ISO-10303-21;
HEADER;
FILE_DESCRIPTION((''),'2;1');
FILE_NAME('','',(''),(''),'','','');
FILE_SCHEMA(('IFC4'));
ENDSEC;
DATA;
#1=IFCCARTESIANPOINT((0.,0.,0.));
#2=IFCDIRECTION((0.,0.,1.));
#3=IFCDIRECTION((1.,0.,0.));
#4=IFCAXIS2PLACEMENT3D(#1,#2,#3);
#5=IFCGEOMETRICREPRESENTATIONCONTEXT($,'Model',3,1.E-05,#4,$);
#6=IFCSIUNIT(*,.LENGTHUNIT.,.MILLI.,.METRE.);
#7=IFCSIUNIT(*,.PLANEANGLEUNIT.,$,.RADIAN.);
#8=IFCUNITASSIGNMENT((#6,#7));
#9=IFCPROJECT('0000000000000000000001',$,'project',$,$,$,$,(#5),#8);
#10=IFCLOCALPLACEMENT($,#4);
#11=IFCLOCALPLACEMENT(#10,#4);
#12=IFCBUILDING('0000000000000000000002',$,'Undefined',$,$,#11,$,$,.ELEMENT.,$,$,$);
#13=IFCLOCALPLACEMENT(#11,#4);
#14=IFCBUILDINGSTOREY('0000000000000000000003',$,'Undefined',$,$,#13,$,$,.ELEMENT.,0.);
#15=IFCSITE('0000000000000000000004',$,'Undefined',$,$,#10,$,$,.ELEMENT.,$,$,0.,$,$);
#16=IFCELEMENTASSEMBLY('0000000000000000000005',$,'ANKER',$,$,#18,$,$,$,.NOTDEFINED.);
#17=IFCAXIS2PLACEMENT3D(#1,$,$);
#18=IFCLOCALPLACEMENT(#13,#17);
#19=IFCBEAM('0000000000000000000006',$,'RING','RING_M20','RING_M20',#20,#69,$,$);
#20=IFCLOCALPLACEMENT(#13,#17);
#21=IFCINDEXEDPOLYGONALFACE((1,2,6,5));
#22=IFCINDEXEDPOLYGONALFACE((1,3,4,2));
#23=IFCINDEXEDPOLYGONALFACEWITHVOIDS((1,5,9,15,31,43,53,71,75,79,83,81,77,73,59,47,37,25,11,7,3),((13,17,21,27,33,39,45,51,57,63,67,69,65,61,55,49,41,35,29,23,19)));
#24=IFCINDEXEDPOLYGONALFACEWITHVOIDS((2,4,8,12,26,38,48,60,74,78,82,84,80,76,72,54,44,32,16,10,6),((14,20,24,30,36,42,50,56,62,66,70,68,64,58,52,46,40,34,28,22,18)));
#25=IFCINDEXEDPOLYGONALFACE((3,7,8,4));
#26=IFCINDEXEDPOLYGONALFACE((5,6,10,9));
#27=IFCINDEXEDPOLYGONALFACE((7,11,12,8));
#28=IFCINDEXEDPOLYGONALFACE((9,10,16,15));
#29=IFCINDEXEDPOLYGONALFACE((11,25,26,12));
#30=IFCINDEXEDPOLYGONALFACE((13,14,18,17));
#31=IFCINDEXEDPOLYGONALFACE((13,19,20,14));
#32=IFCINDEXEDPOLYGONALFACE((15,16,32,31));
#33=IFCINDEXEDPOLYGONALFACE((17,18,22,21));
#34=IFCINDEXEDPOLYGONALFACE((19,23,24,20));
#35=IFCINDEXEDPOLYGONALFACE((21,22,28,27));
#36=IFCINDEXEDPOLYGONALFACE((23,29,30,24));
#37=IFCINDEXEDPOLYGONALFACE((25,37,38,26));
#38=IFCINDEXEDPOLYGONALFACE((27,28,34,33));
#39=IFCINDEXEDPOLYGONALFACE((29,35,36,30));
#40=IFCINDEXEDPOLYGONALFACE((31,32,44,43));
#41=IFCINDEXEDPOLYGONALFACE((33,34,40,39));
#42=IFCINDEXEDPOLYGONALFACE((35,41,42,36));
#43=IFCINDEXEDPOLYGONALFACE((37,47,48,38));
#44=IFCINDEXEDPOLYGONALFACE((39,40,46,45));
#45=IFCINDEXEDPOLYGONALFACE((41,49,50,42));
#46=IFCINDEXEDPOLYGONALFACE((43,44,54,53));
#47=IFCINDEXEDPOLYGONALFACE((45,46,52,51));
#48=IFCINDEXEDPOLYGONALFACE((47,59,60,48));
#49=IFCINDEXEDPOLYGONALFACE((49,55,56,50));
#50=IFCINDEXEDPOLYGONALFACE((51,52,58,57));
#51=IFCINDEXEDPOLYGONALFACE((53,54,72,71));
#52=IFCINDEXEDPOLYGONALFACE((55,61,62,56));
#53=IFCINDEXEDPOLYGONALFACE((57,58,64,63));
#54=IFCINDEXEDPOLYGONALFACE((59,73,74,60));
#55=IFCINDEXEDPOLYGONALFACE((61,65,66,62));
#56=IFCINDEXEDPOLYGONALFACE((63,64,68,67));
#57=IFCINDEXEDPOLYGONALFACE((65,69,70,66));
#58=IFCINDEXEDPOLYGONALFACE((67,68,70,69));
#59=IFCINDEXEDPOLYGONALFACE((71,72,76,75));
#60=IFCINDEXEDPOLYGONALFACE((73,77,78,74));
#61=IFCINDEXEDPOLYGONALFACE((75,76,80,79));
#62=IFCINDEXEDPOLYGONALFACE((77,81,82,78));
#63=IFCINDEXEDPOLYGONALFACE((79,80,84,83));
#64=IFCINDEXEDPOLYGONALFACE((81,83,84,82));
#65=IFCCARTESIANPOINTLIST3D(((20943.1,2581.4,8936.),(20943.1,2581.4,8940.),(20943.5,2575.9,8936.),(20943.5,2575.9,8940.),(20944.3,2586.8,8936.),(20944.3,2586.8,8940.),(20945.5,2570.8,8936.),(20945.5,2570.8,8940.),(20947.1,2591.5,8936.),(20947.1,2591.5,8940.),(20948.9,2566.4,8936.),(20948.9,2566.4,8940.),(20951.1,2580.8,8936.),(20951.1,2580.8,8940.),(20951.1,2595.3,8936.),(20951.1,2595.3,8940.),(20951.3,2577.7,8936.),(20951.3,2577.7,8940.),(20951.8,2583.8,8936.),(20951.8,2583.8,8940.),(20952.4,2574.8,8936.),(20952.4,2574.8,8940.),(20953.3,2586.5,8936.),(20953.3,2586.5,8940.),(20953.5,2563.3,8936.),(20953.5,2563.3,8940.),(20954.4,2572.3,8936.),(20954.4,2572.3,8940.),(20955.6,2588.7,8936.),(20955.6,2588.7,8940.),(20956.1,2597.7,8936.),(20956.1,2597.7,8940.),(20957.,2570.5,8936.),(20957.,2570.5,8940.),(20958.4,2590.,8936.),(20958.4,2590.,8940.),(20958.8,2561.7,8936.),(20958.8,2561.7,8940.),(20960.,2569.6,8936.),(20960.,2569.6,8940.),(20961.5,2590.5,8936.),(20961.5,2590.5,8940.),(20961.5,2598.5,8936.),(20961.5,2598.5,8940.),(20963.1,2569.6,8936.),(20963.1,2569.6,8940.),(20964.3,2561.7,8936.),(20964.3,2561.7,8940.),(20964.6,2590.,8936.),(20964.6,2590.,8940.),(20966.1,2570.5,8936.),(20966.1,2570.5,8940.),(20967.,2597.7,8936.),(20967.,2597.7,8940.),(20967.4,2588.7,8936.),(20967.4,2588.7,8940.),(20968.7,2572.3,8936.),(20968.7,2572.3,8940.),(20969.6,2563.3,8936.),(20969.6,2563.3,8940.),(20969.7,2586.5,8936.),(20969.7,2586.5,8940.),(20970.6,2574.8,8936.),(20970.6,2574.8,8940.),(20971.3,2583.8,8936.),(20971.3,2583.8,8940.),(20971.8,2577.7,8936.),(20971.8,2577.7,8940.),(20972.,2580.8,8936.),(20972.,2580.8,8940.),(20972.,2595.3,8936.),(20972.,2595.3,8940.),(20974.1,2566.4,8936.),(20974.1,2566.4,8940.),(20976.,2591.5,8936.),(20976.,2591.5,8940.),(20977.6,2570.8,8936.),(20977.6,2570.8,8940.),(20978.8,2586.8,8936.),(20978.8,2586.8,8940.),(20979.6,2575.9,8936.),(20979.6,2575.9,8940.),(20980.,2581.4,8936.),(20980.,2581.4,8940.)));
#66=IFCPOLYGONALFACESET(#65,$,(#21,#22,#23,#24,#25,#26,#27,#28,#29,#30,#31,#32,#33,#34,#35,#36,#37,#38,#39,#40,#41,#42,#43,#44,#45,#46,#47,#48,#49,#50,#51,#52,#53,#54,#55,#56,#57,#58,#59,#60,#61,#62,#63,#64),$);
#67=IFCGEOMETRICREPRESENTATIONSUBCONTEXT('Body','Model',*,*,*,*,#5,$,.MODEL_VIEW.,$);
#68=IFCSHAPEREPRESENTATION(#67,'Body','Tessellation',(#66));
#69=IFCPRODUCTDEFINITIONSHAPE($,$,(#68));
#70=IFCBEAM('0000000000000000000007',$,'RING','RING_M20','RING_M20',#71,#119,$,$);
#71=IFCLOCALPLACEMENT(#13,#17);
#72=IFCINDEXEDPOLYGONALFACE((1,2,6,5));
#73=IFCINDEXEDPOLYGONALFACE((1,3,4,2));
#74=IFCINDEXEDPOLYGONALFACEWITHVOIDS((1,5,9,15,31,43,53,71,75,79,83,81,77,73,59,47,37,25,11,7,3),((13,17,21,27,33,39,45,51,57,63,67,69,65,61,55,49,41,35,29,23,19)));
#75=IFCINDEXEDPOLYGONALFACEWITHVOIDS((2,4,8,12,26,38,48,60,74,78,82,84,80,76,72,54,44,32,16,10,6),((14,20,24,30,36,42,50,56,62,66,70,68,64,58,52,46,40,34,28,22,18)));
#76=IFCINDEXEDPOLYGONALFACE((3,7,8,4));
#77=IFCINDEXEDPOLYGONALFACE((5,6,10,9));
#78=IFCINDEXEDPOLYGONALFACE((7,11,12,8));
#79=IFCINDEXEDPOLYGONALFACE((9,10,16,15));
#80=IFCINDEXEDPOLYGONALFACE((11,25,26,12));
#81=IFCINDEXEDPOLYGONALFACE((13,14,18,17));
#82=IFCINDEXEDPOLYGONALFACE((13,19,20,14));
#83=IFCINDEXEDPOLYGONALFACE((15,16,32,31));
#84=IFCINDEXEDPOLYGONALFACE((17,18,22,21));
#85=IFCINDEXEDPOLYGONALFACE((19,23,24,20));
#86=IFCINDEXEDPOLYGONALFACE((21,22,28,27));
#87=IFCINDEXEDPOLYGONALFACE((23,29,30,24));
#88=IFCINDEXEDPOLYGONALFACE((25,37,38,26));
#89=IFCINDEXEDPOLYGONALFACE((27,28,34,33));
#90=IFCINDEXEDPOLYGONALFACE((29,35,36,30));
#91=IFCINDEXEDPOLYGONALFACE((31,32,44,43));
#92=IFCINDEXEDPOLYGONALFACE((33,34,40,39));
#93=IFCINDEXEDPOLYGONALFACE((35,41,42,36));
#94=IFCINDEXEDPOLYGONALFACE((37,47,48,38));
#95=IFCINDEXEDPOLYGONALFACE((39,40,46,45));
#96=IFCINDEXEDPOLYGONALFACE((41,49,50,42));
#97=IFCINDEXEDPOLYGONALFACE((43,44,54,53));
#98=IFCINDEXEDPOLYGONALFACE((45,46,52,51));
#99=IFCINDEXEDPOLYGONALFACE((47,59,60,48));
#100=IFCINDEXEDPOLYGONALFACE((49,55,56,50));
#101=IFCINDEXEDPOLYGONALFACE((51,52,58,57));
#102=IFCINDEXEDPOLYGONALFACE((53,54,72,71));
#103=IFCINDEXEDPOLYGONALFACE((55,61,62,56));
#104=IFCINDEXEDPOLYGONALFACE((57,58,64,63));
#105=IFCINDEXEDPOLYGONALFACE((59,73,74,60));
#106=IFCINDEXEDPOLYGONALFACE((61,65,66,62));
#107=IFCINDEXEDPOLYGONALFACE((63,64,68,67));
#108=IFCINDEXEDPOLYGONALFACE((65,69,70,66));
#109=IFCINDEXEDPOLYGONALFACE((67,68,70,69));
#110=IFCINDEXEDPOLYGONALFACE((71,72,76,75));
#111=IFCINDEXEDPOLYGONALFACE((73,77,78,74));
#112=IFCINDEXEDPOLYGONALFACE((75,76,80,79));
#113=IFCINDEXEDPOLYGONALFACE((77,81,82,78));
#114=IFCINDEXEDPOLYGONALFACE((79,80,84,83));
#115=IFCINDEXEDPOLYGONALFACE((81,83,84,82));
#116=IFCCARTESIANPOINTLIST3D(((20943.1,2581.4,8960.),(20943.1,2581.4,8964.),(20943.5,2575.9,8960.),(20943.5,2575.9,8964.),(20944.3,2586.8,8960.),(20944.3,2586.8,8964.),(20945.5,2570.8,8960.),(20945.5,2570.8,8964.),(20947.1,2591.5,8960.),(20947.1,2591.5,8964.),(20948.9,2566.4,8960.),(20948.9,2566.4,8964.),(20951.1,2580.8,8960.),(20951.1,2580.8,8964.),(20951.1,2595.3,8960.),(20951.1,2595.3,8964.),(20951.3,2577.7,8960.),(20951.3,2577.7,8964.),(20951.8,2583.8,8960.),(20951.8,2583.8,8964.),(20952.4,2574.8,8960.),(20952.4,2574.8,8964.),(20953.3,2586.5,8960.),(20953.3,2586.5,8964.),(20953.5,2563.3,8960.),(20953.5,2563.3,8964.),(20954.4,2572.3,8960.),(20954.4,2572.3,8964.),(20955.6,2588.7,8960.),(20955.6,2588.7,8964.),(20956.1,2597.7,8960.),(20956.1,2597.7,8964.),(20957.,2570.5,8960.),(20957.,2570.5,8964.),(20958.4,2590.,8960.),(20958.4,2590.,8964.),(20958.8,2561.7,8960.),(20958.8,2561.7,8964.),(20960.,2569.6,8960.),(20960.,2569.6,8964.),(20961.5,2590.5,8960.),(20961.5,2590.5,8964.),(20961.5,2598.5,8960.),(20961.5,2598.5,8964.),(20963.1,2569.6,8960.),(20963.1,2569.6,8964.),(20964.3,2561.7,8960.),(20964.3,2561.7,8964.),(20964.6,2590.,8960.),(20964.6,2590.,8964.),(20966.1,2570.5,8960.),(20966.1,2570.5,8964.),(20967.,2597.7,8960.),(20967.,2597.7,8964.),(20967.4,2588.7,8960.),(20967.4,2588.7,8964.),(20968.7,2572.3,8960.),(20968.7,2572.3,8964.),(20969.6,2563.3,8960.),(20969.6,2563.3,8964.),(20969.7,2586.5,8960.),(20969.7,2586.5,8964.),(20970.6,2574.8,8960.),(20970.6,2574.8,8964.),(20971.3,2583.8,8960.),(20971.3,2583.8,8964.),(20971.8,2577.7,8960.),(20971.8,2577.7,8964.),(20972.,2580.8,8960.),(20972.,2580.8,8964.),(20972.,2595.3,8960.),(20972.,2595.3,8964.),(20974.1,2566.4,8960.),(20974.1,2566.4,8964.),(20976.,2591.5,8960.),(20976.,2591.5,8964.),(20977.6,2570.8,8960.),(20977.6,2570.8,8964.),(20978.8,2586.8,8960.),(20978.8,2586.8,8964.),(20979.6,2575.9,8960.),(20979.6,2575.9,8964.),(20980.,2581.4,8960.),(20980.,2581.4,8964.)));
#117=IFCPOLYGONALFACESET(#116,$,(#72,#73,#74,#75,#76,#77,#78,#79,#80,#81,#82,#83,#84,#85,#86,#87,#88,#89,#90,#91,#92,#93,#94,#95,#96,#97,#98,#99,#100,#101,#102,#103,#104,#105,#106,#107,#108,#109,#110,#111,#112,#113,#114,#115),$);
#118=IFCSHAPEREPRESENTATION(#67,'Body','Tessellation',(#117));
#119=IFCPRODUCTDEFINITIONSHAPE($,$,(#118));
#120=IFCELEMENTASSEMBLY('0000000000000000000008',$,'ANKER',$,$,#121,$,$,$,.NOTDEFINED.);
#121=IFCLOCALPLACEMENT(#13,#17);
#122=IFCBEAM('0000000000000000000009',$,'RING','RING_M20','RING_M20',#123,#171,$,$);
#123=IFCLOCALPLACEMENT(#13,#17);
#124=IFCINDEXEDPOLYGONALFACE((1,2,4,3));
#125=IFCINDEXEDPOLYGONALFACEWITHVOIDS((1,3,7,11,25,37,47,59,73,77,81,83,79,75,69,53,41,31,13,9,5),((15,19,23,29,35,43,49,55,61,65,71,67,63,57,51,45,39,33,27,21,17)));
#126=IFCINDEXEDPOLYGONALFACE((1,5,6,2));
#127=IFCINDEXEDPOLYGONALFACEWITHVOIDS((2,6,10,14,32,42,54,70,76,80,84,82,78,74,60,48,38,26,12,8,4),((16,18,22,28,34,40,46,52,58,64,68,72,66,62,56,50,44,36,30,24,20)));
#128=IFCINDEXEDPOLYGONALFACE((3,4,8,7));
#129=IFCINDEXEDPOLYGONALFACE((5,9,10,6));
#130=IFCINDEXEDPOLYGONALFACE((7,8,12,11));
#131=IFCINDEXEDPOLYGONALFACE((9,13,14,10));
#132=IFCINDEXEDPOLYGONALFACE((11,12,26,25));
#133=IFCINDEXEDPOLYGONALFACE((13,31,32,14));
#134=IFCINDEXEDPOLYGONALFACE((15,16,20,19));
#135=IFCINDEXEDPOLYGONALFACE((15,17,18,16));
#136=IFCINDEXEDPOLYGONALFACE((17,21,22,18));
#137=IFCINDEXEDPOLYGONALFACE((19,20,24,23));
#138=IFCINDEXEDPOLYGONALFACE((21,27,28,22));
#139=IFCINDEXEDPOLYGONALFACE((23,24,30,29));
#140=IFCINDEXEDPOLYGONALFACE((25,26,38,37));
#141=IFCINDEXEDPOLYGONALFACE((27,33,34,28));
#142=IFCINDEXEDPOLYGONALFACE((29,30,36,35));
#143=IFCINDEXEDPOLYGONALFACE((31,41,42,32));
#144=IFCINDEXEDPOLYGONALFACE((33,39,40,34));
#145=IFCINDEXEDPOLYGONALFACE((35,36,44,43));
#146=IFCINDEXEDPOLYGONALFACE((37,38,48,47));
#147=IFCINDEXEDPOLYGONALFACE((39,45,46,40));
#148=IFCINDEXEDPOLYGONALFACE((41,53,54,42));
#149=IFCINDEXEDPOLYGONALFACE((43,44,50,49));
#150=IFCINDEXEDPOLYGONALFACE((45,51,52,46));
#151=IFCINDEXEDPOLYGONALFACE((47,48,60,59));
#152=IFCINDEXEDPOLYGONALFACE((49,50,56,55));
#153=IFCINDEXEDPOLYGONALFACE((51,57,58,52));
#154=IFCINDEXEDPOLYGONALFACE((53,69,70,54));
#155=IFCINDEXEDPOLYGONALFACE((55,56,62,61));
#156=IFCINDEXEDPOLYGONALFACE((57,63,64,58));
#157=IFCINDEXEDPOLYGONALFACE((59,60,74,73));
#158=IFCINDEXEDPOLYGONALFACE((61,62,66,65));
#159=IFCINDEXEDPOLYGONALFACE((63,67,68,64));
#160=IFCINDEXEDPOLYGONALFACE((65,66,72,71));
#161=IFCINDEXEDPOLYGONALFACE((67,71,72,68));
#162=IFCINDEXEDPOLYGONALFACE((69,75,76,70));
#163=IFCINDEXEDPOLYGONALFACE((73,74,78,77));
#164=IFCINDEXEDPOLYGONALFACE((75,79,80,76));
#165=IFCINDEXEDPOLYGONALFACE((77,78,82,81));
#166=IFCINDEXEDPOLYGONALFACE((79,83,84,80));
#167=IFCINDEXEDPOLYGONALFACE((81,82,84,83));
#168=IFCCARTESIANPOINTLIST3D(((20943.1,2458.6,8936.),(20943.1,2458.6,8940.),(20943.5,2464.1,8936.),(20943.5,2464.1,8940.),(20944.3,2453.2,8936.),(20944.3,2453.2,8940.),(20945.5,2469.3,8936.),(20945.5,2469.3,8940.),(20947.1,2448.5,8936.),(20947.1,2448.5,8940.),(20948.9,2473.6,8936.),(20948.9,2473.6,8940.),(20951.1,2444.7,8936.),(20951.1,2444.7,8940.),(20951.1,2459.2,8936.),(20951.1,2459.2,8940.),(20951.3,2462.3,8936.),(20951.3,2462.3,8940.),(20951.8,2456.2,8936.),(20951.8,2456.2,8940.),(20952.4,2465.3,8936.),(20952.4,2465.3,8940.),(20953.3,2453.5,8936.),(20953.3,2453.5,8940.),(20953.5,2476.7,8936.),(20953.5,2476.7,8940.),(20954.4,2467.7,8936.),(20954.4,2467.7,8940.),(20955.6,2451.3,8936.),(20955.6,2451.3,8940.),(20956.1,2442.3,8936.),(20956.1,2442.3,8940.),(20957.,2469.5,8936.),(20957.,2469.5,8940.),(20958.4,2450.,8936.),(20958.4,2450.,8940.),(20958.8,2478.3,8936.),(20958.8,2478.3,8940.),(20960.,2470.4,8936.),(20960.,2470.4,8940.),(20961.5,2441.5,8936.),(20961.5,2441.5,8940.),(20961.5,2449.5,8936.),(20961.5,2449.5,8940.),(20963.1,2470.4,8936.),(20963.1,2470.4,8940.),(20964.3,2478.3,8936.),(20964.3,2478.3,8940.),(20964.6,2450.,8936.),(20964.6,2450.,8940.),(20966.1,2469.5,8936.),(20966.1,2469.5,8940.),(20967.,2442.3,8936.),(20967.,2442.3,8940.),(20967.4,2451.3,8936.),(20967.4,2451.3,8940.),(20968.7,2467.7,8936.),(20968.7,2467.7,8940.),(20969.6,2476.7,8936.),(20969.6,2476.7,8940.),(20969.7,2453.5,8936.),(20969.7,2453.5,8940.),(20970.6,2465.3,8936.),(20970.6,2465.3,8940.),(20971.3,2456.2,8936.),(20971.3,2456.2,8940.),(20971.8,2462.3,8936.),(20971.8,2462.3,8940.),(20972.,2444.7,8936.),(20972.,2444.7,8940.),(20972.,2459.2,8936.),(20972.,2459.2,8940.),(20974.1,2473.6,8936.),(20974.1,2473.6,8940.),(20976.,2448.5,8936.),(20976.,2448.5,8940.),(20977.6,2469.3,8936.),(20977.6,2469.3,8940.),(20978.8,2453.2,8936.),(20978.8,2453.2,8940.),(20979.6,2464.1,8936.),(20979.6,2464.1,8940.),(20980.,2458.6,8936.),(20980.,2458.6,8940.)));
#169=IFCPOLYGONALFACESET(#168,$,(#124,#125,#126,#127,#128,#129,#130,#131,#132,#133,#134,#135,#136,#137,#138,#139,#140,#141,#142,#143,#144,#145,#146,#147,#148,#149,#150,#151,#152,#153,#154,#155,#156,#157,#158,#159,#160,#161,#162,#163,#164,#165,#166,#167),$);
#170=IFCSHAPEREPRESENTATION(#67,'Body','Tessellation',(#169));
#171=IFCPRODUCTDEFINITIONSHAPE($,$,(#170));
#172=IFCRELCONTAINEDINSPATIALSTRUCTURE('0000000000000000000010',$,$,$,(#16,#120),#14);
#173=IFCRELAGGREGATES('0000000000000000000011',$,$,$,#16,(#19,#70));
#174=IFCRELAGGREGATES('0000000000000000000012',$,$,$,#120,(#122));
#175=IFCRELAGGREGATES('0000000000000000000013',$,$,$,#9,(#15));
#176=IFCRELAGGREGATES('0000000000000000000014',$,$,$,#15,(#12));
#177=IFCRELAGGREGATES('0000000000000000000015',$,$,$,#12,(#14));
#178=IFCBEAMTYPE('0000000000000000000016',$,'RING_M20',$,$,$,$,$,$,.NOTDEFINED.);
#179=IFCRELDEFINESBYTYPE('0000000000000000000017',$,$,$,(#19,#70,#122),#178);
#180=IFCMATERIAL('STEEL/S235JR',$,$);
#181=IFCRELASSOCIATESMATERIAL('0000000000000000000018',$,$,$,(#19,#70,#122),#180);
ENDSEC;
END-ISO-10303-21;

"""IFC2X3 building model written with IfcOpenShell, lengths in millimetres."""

from ifc_helpers import new_model, si_unit, frame, origin_with_axes, origin_2d_with_axis, place, context, subcontext, project, spatial, hollow_circle, extrude, material, type_object, element, aggregate, save


model = new_model("IFC2X3")

# Units and contexts
model_context = context("Model", 3, precision=1e-05, world=origin_with_axes())
body_context = subcontext(model_context, "Body", "Model", "MODEL_VIEW")
ifc_project = project(units=[si_unit("LENGTHUNIT", "METRE", prefix="MILLI"), si_unit("PLANEANGLEUNIT", "RADIAN")], contexts=[model_context])

# Site, building, storey
site_placement = place(None, origin_with_axes())
site = spatial("IfcSite", under=ifc_project, at=site_placement, Name="Undefined", CompositionType="ELEMENT", RefElevation=0.0)
building_placement = place(site_placement, origin_with_axes())
building = spatial("IfcBuilding", under=site, at=building_placement, Name="Undefined", CompositionType="ELEMENT")
storey_placement = place(building_placement, origin_with_axes())
storey = spatial("IfcBuildingStorey", under=building, at=storey_placement, Name="Undefined", CompositionType="ELEMENT", Elevation=0.0)

# Shared definitions
ifc_material = material(Name="STEEL/S235JR")

# Element assemblies, beams
beam_type_1 = type_object("IfcBeamType", Name="RING_M20", PredefinedType="NOTDEFINED")
assembly_1_placement = place(storey_placement, frame((20961.5, 2580.0, 9010.0), z_axis=(0.0, 1.0, 0.0), x_axis=(0.0, 0.0, -1.0)))
assembly_1 = element("IfcElementAssembly", 1, at=assembly_1_placement, inside=storey, Name="ANKER", PredefinedType="NOTDEFINED")
beam_1_placement = place(storey_placement, frame((20961.5, 2580.0, 8940.0), z_axis=(-1.0, 0.0, 0.0), x_axis=(0.0, 0.0, -1.0)))
beam_1 = element("IfcBeam", 2, at=beam_1_placement, type_object=beam_type_1, material=ifc_material, Name="RING", Description="RING_M20", ObjectType="RING_M20", context=body_context, shape_type="SweptSolid", body=[
    extrude(hollow_circle(Radius=18.5, WallThickness=8.0, at=origin_2d_with_axis()), frame((4.0, 0.0, 0.0), z_axis=(-1.0, 0.0, 0.0), x_axis=(0.0, -1.0, 0.0)), (0.0, 0.0, 1.0), 4.0),
])
beam_2_placement = place(storey_placement, frame((20961.5, 2580.0, 8964.0), z_axis=(-1.0, 0.0, 0.0), x_axis=(0.0, 0.0, -1.0)))
beam_2 = element("IfcBeam", 3, at=beam_2_placement, type_object=beam_type_1, material=ifc_material, Name="RING", Description="RING_M20", ObjectType="RING_M20", context=body_context, shape_type="SweptSolid", body=[
    extrude(hollow_circle(Radius=18.5, WallThickness=8.0, at=origin_2d_with_axis()), frame((4.0, 0.0, 0.0), z_axis=(-1.0, 0.0, 0.0), x_axis=(0.0, -1.0, 0.0)), (0.0, 0.0, 1.0), 4.0),
])
aggregate(assembly_1, [beam_1, beam_2])
assembly_2_placement = place(storey_placement, frame((20961.5, 2460.0, 9010.0), z_axis=(0.0, 1.0, 0.0), x_axis=(0.0, 0.0, -1.0)))
assembly_2 = element("IfcElementAssembly", 4, at=assembly_2_placement, inside=storey, Name="ANKER", PredefinedType="NOTDEFINED")
beam_3_placement = place(storey_placement, frame((20961.5, 2460.0, 8940.0), z_axis=(1.0, 0.0, 0.0), x_axis=(0.0, 0.0, -1.0)))
beam_3 = element("IfcBeam", 5, at=beam_3_placement, type_object=beam_type_1, material=ifc_material, Name="RING", Description="RING_M20", ObjectType="RING_M20", context=body_context, shape_type="SweptSolid", body=[
    extrude(hollow_circle(Radius=18.5, WallThickness=8.0, at=origin_2d_with_axis()), frame((4.0, 0.0, 0.0), z_axis=(-1.0, 0.0, 0.0), x_axis=(0.0, -1.0, 0.0)), (0.0, 0.0, 1.0), 4.0),
])
aggregate(assembly_2, [beam_3])

save(model, "model.ifc")
